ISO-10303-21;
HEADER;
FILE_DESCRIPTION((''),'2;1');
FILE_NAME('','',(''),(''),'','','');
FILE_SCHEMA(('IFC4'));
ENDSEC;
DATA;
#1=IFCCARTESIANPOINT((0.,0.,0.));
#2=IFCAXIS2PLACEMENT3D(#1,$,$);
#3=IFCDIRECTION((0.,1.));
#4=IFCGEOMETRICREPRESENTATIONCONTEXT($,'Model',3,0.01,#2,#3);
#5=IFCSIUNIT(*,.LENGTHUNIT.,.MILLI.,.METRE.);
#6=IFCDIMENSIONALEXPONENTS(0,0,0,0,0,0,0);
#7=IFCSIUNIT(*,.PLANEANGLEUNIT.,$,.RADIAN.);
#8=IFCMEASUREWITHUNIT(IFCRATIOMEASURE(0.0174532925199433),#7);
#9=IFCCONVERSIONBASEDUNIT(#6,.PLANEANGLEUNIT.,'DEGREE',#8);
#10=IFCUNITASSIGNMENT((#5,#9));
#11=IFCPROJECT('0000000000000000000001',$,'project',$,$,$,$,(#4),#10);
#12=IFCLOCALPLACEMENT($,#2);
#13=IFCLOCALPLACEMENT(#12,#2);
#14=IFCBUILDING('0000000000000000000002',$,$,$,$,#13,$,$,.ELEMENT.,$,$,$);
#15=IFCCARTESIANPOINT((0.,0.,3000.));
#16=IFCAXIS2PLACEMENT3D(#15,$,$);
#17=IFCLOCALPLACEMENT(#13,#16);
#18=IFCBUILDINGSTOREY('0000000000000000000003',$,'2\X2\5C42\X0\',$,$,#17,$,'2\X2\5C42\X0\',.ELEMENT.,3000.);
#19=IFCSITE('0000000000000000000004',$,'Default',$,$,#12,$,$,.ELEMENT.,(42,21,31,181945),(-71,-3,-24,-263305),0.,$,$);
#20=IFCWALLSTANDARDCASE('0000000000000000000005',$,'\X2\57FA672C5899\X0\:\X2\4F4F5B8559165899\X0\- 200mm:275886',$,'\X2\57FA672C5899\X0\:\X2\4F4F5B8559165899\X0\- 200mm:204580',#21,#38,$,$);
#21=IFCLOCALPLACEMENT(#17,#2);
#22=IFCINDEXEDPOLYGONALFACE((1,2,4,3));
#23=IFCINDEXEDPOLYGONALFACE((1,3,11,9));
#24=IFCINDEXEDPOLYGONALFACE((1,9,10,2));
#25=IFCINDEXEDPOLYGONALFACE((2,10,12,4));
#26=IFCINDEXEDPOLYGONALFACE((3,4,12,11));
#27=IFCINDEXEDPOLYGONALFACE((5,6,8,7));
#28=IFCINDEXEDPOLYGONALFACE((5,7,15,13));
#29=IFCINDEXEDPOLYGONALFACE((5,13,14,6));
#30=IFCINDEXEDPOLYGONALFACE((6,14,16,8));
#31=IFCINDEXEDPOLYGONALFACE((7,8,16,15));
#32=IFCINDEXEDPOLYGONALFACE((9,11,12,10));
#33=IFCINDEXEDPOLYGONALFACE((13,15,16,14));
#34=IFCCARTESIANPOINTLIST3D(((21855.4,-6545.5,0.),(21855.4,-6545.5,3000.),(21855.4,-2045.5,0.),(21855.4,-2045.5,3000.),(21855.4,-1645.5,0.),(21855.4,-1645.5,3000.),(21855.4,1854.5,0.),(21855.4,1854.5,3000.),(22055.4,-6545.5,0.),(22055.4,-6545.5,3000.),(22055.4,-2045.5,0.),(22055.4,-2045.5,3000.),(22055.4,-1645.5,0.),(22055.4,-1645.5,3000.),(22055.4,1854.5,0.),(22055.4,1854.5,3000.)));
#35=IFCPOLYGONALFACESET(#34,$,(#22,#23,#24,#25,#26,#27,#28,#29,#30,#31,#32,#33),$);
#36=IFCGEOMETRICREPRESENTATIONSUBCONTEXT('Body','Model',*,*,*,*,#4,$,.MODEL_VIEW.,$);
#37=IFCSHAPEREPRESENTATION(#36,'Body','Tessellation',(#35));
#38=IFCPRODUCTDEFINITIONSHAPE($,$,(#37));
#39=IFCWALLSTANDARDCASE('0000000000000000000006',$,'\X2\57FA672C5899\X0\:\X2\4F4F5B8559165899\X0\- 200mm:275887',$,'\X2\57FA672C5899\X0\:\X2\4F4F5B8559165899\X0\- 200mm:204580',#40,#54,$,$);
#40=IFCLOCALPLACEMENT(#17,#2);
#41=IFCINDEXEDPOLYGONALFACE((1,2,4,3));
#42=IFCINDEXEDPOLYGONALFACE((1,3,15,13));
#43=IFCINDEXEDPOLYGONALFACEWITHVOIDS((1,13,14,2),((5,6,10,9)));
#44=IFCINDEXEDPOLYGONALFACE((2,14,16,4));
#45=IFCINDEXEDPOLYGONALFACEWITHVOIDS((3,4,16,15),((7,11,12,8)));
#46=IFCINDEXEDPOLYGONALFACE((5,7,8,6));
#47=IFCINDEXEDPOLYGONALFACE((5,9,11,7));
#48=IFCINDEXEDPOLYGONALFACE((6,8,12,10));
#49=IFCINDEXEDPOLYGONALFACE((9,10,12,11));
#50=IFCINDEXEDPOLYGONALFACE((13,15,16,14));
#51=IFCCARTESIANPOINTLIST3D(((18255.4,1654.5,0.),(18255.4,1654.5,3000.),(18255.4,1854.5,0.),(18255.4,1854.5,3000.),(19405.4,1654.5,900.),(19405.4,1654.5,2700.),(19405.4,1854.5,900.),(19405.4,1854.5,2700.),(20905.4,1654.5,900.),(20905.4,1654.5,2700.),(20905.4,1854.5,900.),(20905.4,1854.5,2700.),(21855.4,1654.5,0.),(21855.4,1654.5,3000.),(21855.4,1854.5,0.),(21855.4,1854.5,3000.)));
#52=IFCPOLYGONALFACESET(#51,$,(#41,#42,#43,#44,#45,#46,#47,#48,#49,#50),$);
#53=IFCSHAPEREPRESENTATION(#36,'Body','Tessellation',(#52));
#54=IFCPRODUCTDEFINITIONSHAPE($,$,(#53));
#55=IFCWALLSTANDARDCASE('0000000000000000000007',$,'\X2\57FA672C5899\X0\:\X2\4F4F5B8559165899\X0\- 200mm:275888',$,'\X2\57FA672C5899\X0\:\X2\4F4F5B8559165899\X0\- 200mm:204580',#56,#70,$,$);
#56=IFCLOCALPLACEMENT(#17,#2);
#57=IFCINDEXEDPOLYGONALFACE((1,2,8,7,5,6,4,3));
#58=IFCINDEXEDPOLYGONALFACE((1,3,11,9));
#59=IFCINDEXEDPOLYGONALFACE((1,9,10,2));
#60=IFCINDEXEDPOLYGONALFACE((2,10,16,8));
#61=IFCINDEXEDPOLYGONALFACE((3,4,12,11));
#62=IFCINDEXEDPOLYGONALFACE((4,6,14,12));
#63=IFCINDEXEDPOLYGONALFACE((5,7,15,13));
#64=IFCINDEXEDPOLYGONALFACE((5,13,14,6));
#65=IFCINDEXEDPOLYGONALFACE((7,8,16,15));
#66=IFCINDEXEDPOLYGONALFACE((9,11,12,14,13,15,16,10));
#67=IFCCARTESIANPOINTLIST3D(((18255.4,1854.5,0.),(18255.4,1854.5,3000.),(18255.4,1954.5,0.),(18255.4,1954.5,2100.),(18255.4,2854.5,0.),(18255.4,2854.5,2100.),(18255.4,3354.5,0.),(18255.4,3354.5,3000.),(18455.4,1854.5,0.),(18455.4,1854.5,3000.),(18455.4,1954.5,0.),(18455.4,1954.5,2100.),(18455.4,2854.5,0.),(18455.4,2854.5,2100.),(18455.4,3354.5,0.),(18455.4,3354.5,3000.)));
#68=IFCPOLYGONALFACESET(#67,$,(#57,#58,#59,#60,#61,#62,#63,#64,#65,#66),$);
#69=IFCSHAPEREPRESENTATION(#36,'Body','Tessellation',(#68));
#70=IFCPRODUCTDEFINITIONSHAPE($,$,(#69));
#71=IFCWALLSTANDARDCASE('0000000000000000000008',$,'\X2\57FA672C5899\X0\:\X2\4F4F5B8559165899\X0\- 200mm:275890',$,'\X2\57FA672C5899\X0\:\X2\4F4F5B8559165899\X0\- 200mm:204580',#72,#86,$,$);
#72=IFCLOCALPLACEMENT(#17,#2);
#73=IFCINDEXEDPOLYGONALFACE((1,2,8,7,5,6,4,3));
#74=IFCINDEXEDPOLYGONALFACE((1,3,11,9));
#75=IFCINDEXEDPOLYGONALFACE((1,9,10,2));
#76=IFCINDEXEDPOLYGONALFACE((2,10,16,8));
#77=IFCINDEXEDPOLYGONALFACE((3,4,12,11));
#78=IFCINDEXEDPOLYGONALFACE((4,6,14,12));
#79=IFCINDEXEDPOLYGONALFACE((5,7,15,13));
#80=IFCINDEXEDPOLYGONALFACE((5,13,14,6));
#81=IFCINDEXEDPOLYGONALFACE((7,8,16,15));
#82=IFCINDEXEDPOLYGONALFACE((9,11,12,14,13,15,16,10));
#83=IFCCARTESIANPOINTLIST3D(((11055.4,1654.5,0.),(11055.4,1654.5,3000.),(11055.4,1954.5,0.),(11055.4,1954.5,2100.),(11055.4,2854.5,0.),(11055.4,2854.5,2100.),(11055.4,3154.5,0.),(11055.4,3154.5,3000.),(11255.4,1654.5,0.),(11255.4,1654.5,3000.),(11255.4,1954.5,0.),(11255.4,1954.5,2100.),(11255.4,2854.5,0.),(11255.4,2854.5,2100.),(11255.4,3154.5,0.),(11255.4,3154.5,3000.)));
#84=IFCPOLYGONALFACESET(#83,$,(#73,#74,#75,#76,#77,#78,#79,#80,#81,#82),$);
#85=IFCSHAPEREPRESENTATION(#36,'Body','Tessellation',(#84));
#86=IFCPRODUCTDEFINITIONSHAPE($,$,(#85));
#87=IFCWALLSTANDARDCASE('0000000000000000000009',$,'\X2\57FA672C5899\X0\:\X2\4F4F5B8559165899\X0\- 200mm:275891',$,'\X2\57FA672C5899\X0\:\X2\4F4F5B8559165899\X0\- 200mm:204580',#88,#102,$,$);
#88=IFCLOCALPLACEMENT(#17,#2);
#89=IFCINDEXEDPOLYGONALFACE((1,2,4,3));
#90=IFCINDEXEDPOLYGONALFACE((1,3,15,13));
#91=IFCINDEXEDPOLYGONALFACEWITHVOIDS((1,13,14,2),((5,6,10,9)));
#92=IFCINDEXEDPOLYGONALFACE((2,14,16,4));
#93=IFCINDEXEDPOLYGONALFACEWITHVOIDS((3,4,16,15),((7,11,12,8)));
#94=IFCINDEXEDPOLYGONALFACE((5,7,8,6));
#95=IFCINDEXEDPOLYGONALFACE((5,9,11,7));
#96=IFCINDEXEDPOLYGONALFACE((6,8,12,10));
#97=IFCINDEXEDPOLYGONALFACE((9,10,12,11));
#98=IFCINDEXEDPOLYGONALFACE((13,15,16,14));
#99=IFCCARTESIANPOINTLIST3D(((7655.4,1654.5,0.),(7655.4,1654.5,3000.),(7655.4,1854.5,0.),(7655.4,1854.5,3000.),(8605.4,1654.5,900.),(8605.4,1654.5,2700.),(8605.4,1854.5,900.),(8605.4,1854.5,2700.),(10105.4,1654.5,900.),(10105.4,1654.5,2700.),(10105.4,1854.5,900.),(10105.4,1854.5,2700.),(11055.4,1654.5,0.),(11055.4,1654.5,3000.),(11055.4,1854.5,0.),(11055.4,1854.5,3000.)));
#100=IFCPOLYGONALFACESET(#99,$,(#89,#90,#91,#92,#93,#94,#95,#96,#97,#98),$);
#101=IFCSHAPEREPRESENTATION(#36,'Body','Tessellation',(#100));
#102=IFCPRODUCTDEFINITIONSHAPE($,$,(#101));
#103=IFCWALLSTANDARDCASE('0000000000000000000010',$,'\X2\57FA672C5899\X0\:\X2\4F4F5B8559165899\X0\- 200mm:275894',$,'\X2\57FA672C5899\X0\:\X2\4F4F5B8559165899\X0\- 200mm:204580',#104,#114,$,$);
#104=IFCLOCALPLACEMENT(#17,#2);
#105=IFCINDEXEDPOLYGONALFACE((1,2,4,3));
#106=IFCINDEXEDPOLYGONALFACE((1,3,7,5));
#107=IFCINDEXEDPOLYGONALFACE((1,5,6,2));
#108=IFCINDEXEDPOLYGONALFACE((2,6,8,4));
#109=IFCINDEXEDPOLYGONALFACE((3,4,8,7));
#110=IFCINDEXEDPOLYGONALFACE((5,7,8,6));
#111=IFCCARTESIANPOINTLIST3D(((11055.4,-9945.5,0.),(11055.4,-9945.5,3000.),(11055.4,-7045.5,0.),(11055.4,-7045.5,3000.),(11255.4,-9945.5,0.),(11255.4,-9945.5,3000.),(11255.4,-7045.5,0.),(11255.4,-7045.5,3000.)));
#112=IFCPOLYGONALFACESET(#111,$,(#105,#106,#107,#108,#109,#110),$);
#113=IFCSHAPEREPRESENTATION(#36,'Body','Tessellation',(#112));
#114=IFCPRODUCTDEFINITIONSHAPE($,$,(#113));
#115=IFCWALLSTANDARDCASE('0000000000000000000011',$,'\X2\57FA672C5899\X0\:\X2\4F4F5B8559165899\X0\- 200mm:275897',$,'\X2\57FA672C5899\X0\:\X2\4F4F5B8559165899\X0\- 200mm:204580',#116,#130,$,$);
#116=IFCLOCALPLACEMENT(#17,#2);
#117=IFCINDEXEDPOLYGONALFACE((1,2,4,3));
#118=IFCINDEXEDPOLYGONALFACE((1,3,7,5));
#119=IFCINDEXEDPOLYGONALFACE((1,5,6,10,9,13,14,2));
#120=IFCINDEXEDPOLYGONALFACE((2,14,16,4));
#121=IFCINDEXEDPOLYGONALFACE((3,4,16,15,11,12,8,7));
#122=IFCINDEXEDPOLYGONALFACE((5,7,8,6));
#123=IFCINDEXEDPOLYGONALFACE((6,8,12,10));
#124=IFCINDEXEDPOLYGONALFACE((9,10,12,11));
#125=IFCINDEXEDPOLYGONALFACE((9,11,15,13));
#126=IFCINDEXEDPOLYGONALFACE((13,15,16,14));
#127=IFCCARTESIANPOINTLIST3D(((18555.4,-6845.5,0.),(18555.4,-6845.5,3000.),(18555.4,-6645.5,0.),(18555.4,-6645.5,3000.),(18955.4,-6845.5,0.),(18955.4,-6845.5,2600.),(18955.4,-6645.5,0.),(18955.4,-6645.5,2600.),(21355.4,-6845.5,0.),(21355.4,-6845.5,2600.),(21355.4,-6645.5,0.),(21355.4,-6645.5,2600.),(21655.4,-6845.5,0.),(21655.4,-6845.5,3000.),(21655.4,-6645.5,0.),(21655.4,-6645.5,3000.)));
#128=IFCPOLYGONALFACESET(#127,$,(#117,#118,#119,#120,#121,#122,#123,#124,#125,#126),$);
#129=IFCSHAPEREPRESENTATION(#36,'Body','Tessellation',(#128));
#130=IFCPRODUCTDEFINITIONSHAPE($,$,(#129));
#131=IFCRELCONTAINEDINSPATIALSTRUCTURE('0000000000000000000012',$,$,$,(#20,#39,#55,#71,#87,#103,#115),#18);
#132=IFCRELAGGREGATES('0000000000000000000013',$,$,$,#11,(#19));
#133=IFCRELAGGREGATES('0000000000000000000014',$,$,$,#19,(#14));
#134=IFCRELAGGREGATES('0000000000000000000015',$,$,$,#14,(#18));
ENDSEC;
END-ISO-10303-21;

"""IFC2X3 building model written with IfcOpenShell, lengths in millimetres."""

from ifc_helpers import new_model, entity, si_unit, converted_unit, direction, frame, frame_2d, origin, place, context, subcontext, project, spatial, polyline, rectangle, extrude, clip, bounded_halfspace, element, save


model = new_model("IFC2X3")

# Units and contexts
model_context = context("Model", 3, precision=0.01, world=origin(), true_north=direction((0.0, 1.0)))
body_context = subcontext(model_context, "Body", "Model", "MODEL_VIEW")
ifc_project = project(units=[si_unit("LENGTHUNIT", "METRE", prefix="MILLI"), converted_unit("PLANEANGLEUNIT", "DEGREE", entity("IfcRatioMeasure", 0.0174532925199433), si_unit("PLANEANGLEUNIT", "RADIAN"), dimensions=[0, 0, 0, 0, 0, 0, 0])], contexts=[model_context])

# Site, building, storey
site_placement = place(None, origin())
site = spatial("IfcSite", under=ifc_project, at=site_placement, Name="Default", CompositionType="ELEMENT", RefLatitude=(42, 21, 31, 181945), RefLongitude=(-71, -3, -24, -263305), RefElevation=0.0)
building_placement = place(site_placement, origin())
building = spatial("IfcBuilding", under=site, at=building_placement, CompositionType="ELEMENT")
storey_placement = place(building_placement, frame((0.0, 0.0, 3000.0)))
storey = spatial("IfcBuildingStorey", under=building, at=storey_placement, Name="2层", LongName="2层", CompositionType="ELEMENT", Elevation=3000.0)

# Walls, openings
wall_1_placement = place(storey_placement, frame((21955.4, -6545.5, 0.0), z_axis=(0.0, 0.0, 1.0), x_axis=(0.0, 1.0, 0.0)))
wall_1 = element("IfcWallStandardCase", 1, at=wall_1_placement, inside=storey, Name="基本墙:住宅外墙- 200mm:275886", ObjectType="基本墙:住宅外墙- 200mm:204580", context=body_context, shape_type="Clipping", body=[
    clip(extrude(rectangle(XDim=8400.0, YDim=200.0, at=frame_2d((4200.0, 0.0), x_axis=(-1.0, 0.0))), origin(), (0.0, 0.0, 1.0), 3000.0), bounded_halfspace(frame((0.0, -100.0, 0.0), z_axis=(-1.0, 0.0, 0.0), x_axis=(0.0, 0.0, -1.0)), False, frame((0.0, -100.0, 0.0), z_axis=(-1.0, 0.0, 0.0), x_axis=(0.0, 0.0, -1.0)), polyline([(0.0, 0.0), (-3000.0, 0.0), (-3000.0, -200.0), (0.0, -200.0), (0.0, 0.0)]))),
])
opening_1_placement = place(storey_placement, frame((21955.4, -6545.5, 0.0), z_axis=(0.0, 0.0, 1.0), x_axis=(0.0, 1.0, 0.0)))
element("IfcOpeningElement", 2, at=opening_1_placement, cuts=wall_1, ObjectType="Opening", context=body_context, shape_type="SweptSolid", body=[
    extrude(rectangle(XDim=3000.0, YDim=200.0, at=frame_2d((0.0, 0.0), x_axis=(1.0, 0.0))), frame((4500.0, 0.0, 1500.0), z_axis=(1.0, 0.0, 0.0), x_axis=(0.0, 0.0, -1.0)), (0.0, 0.0, 1.0), 400.0),
])
wall_2_placement = place(storey_placement, frame((21855.4, 1754.5, 0.0), z_axis=(0.0, 0.0, 1.0), x_axis=(-1.0, 0.0, 0.0)))
wall_2 = element("IfcWallStandardCase", 3, at=wall_2_placement, inside=storey, Name="基本墙:住宅外墙- 200mm:275887", ObjectType="基本墙:住宅外墙- 200mm:204580", context=body_context, shape_type="SweptSolid", body=[
    extrude(rectangle(XDim=3600.0, YDim=200.0, at=frame_2d((1800.0, 0.0), x_axis=(-1.0, 0.0))), origin(), (0.0, 0.0, 1.0), 3000.0),
])
opening_2_placement = place(wall_2_placement, frame((2450.0, 100.0, 900.0)))
element("IfcOpeningElement", 4, at=opening_2_placement, cuts=wall_2, ObjectType="Opening", context=body_context, shape_type="SweptSolid", body=[
    extrude(rectangle(XDim=1800.0, YDim=1500.0, at=frame_2d((900.0, 750.0), x_axis=(1.0, 0.0))), frame((0.0, 0.0, 0.0), z_axis=(0.0, -1.0, 0.0), x_axis=(0.0, 0.0, 1.0)), (0.0, 0.0, 1.0), 200.0),
])
wall_3_placement = place(storey_placement, frame((18355.4, 1854.5, 0.0), z_axis=(0.0, 0.0, 1.0), x_axis=(0.0, 1.0, 0.0)))
wall_3 = element("IfcWallStandardCase", 5, at=wall_3_placement, inside=storey, Name="基本墙:住宅外墙- 200mm:275888", ObjectType="基本墙:住宅外墙- 200mm:204580", context=body_context, shape_type="SweptSolid", body=[
    extrude(rectangle(XDim=1500.0, YDim=200.0, at=frame_2d((750.0, 0.0), x_axis=(-1.0, 0.0))), origin(), (0.0, 0.0, 1.0), 3000.0),
])
opening_3_placement = place(wall_3_placement, frame((1000.0, 100.0, 0.0)))
element("IfcOpeningElement", 6, at=opening_3_placement, cuts=wall_3, ObjectType="Opening", context=body_context, shape_type="SweptSolid", body=[
    extrude(rectangle(XDim=2100.0, YDim=900.0, at=frame_2d((1050.0, 450.0), x_axis=(1.0, 0.0))), frame((0.0, 0.0, 0.0), z_axis=(0.0, -1.0, 0.0), x_axis=(0.0, 0.0, 1.0)), (0.0, 0.0, 1.0), 200.0),
])
wall_4_placement = place(storey_placement, frame((11155.4, 3154.5, 0.0), z_axis=(0.0, 0.0, 1.0), x_axis=(0.0, -1.0, 0.0)))
wall_4 = element("IfcWallStandardCase", 7, at=wall_4_placement, inside=storey, Name="基本墙:住宅外墙- 200mm:275890", ObjectType="基本墙:住宅外墙- 200mm:204580", context=body_context, shape_type="SweptSolid", body=[
    extrude(rectangle(XDim=1500.0, YDim=200.0, at=frame_2d((750.0, 0.0), x_axis=(-1.0, 0.0))), origin(), (0.0, 0.0, 1.0), 3000.0),
])
opening_4_placement = place(wall_4_placement, frame((1200.0, 100.0, 0.0)))
element("IfcOpeningElement", 8, at=opening_4_placement, cuts=wall_4, ObjectType="Opening", context=body_context, shape_type="SweptSolid", body=[
    extrude(rectangle(XDim=2100.0, YDim=900.0, at=frame_2d((1050.0, 450.0), x_axis=(1.0, 0.0))), frame((0.0, 0.0, 0.0), z_axis=(0.0, -1.0, 0.0), x_axis=(0.0, 0.0, 1.0)), (0.0, 0.0, 1.0), 200.0),
])
wall_5_placement = place(storey_placement, frame((11055.4, 1754.5, 0.0), z_axis=(0.0, 0.0, 1.0), x_axis=(-1.0, 0.0, 0.0)))
wall_5 = element("IfcWallStandardCase", 9, at=wall_5_placement, inside=storey, Name="基本墙:住宅外墙- 200mm:275891", ObjectType="基本墙:住宅外墙- 200mm:204580", context=body_context, shape_type="SweptSolid", body=[
    extrude(rectangle(XDim=3400.0, YDim=200.0, at=frame_2d((1700.0, 0.0), x_axis=(-1.0, 0.0))), origin(), (0.0, 0.0, 1.0), 3000.0),
])
opening_5_placement = place(wall_5_placement, frame((950.0, -100.0, 900.0)))
element("IfcOpeningElement", 10, at=opening_5_placement, cuts=wall_5, ObjectType="Opening", context=body_context, shape_type="SweptSolid", body=[
    extrude(rectangle(XDim=1800.0, YDim=1500.0, at=frame_2d((900.0, 750.0), x_axis=(1.0, 0.0))), frame((0.0, 0.0, 0.0), z_axis=(0.0, 1.0, 0.0), x_axis=(0.0, 0.0, 1.0)), (0.0, 0.0, 1.0), 200.0),
])

# Wall
wall_6_placement = place(storey_placement, frame((11155.4, -7045.5, 0.0), z_axis=(0.0, 0.0, 1.0), x_axis=(0.0, -1.0, 0.0)))
element("IfcWallStandardCase", 11, at=wall_6_placement, inside=storey, Name="基本墙:住宅外墙- 200mm:275894", ObjectType="基本墙:住宅外墙- 200mm:204580", context=body_context, shape_type="Clipping", body=[
    clip(clip(extrude(rectangle(XDim=2900.0, YDim=200.0, at=frame_2d((1450.0, 0.0), x_axis=(-1.0, 0.0))), origin(), (0.0, 0.0, 1.0), 3000.0), bounded_halfspace(frame((0.0, -100.0, 0.0), z_axis=(1.0, 0.0, 0.0), x_axis=(0.0, 0.0, -1.0)), True, frame((0.0, -100.0, 0.0), z_axis=(1.0, 0.0, 0.0), x_axis=(0.0, 0.0, -1.0)), polyline([(0.0, 0.0), (0.0, 200.0), (-3000.0, 200.0), (-3000.0, 0.0), (0.0, 0.0)]))), bounded_halfspace(frame((2900.0, -100.0, 3000.0), z_axis=(-1.0, 0.0, 0.0), x_axis=(0.0, 0.0, -1.0)), True, frame((2900.0, -100.0, 3000.0), z_axis=(-1.0, 0.0, 0.0), x_axis=(0.0, 0.0, -1.0)), polyline([(0.0, 0.0), (0.0, -200.0), (3000.0, -200.0), (3000.0, 0.0), (0.0, 0.0)]))),
])

# Wall, opening
wall_7_placement = place(storey_placement, frame((18555.4, -6745.5, 0.0)))
wall_7 = element("IfcWallStandardCase", 12, at=wall_7_placement, inside=storey, Name="基本墙:住宅外墙- 200mm:275897", ObjectType="基本墙:住宅外墙- 200mm:204580", context=body_context, shape_type="Clipping", body=[
    clip(clip(extrude(rectangle(XDim=3100.0, YDim=200.0, at=frame_2d((1550.0, 0.0), x_axis=(-1.0, 0.0))), origin(), (0.0, 0.0, 1.0), 3000.0), bounded_halfspace(frame((0.0, -100.0, 0.0), z_axis=(-1.0, 0.0, 0.0), x_axis=(0.0, 0.0, -1.0)), False, frame((0.0, -100.0, 0.0), z_axis=(-1.0, 0.0, 0.0), x_axis=(0.0, 0.0, -1.0)), polyline([(0.0, 0.0), (-3000.0, 0.0), (-3000.0, -200.0), (0.0, -200.0), (0.0, 0.0)]))), bounded_halfspace(frame((3100.0, -100.0, 3000.0), z_axis=(1.0, 0.0, 0.0), x_axis=(0.0, 0.0, -1.0)), False, frame((3100.0, -100.0, 3000.0), z_axis=(1.0, 0.0, 0.0), x_axis=(0.0, 0.0, -1.0)), polyline([(0.0, 0.0), (3000.0, 0.0), (3000.0, 200.0), (0.0, 200.0), (0.0, 0.0)]))),
])
opening_6_placement = place(wall_7_placement, frame((2800.0, 100.0, 0.0)))
element("IfcOpeningElement", 13, at=opening_6_placement, cuts=wall_7, ObjectType="Opening", context=body_context, shape_type="SweptSolid", body=[
    extrude(rectangle(XDim=2600.0, YDim=2400.0, at=frame_2d((1300.0, 1200.0), x_axis=(1.0, 0.0))), frame((0.0, 0.0, 0.0), z_axis=(0.0, -1.0, 0.0), x_axis=(0.0, 0.0, 1.0)), (0.0, 0.0, 1.0), 200.0),
])

save(model, "model.ifc")
